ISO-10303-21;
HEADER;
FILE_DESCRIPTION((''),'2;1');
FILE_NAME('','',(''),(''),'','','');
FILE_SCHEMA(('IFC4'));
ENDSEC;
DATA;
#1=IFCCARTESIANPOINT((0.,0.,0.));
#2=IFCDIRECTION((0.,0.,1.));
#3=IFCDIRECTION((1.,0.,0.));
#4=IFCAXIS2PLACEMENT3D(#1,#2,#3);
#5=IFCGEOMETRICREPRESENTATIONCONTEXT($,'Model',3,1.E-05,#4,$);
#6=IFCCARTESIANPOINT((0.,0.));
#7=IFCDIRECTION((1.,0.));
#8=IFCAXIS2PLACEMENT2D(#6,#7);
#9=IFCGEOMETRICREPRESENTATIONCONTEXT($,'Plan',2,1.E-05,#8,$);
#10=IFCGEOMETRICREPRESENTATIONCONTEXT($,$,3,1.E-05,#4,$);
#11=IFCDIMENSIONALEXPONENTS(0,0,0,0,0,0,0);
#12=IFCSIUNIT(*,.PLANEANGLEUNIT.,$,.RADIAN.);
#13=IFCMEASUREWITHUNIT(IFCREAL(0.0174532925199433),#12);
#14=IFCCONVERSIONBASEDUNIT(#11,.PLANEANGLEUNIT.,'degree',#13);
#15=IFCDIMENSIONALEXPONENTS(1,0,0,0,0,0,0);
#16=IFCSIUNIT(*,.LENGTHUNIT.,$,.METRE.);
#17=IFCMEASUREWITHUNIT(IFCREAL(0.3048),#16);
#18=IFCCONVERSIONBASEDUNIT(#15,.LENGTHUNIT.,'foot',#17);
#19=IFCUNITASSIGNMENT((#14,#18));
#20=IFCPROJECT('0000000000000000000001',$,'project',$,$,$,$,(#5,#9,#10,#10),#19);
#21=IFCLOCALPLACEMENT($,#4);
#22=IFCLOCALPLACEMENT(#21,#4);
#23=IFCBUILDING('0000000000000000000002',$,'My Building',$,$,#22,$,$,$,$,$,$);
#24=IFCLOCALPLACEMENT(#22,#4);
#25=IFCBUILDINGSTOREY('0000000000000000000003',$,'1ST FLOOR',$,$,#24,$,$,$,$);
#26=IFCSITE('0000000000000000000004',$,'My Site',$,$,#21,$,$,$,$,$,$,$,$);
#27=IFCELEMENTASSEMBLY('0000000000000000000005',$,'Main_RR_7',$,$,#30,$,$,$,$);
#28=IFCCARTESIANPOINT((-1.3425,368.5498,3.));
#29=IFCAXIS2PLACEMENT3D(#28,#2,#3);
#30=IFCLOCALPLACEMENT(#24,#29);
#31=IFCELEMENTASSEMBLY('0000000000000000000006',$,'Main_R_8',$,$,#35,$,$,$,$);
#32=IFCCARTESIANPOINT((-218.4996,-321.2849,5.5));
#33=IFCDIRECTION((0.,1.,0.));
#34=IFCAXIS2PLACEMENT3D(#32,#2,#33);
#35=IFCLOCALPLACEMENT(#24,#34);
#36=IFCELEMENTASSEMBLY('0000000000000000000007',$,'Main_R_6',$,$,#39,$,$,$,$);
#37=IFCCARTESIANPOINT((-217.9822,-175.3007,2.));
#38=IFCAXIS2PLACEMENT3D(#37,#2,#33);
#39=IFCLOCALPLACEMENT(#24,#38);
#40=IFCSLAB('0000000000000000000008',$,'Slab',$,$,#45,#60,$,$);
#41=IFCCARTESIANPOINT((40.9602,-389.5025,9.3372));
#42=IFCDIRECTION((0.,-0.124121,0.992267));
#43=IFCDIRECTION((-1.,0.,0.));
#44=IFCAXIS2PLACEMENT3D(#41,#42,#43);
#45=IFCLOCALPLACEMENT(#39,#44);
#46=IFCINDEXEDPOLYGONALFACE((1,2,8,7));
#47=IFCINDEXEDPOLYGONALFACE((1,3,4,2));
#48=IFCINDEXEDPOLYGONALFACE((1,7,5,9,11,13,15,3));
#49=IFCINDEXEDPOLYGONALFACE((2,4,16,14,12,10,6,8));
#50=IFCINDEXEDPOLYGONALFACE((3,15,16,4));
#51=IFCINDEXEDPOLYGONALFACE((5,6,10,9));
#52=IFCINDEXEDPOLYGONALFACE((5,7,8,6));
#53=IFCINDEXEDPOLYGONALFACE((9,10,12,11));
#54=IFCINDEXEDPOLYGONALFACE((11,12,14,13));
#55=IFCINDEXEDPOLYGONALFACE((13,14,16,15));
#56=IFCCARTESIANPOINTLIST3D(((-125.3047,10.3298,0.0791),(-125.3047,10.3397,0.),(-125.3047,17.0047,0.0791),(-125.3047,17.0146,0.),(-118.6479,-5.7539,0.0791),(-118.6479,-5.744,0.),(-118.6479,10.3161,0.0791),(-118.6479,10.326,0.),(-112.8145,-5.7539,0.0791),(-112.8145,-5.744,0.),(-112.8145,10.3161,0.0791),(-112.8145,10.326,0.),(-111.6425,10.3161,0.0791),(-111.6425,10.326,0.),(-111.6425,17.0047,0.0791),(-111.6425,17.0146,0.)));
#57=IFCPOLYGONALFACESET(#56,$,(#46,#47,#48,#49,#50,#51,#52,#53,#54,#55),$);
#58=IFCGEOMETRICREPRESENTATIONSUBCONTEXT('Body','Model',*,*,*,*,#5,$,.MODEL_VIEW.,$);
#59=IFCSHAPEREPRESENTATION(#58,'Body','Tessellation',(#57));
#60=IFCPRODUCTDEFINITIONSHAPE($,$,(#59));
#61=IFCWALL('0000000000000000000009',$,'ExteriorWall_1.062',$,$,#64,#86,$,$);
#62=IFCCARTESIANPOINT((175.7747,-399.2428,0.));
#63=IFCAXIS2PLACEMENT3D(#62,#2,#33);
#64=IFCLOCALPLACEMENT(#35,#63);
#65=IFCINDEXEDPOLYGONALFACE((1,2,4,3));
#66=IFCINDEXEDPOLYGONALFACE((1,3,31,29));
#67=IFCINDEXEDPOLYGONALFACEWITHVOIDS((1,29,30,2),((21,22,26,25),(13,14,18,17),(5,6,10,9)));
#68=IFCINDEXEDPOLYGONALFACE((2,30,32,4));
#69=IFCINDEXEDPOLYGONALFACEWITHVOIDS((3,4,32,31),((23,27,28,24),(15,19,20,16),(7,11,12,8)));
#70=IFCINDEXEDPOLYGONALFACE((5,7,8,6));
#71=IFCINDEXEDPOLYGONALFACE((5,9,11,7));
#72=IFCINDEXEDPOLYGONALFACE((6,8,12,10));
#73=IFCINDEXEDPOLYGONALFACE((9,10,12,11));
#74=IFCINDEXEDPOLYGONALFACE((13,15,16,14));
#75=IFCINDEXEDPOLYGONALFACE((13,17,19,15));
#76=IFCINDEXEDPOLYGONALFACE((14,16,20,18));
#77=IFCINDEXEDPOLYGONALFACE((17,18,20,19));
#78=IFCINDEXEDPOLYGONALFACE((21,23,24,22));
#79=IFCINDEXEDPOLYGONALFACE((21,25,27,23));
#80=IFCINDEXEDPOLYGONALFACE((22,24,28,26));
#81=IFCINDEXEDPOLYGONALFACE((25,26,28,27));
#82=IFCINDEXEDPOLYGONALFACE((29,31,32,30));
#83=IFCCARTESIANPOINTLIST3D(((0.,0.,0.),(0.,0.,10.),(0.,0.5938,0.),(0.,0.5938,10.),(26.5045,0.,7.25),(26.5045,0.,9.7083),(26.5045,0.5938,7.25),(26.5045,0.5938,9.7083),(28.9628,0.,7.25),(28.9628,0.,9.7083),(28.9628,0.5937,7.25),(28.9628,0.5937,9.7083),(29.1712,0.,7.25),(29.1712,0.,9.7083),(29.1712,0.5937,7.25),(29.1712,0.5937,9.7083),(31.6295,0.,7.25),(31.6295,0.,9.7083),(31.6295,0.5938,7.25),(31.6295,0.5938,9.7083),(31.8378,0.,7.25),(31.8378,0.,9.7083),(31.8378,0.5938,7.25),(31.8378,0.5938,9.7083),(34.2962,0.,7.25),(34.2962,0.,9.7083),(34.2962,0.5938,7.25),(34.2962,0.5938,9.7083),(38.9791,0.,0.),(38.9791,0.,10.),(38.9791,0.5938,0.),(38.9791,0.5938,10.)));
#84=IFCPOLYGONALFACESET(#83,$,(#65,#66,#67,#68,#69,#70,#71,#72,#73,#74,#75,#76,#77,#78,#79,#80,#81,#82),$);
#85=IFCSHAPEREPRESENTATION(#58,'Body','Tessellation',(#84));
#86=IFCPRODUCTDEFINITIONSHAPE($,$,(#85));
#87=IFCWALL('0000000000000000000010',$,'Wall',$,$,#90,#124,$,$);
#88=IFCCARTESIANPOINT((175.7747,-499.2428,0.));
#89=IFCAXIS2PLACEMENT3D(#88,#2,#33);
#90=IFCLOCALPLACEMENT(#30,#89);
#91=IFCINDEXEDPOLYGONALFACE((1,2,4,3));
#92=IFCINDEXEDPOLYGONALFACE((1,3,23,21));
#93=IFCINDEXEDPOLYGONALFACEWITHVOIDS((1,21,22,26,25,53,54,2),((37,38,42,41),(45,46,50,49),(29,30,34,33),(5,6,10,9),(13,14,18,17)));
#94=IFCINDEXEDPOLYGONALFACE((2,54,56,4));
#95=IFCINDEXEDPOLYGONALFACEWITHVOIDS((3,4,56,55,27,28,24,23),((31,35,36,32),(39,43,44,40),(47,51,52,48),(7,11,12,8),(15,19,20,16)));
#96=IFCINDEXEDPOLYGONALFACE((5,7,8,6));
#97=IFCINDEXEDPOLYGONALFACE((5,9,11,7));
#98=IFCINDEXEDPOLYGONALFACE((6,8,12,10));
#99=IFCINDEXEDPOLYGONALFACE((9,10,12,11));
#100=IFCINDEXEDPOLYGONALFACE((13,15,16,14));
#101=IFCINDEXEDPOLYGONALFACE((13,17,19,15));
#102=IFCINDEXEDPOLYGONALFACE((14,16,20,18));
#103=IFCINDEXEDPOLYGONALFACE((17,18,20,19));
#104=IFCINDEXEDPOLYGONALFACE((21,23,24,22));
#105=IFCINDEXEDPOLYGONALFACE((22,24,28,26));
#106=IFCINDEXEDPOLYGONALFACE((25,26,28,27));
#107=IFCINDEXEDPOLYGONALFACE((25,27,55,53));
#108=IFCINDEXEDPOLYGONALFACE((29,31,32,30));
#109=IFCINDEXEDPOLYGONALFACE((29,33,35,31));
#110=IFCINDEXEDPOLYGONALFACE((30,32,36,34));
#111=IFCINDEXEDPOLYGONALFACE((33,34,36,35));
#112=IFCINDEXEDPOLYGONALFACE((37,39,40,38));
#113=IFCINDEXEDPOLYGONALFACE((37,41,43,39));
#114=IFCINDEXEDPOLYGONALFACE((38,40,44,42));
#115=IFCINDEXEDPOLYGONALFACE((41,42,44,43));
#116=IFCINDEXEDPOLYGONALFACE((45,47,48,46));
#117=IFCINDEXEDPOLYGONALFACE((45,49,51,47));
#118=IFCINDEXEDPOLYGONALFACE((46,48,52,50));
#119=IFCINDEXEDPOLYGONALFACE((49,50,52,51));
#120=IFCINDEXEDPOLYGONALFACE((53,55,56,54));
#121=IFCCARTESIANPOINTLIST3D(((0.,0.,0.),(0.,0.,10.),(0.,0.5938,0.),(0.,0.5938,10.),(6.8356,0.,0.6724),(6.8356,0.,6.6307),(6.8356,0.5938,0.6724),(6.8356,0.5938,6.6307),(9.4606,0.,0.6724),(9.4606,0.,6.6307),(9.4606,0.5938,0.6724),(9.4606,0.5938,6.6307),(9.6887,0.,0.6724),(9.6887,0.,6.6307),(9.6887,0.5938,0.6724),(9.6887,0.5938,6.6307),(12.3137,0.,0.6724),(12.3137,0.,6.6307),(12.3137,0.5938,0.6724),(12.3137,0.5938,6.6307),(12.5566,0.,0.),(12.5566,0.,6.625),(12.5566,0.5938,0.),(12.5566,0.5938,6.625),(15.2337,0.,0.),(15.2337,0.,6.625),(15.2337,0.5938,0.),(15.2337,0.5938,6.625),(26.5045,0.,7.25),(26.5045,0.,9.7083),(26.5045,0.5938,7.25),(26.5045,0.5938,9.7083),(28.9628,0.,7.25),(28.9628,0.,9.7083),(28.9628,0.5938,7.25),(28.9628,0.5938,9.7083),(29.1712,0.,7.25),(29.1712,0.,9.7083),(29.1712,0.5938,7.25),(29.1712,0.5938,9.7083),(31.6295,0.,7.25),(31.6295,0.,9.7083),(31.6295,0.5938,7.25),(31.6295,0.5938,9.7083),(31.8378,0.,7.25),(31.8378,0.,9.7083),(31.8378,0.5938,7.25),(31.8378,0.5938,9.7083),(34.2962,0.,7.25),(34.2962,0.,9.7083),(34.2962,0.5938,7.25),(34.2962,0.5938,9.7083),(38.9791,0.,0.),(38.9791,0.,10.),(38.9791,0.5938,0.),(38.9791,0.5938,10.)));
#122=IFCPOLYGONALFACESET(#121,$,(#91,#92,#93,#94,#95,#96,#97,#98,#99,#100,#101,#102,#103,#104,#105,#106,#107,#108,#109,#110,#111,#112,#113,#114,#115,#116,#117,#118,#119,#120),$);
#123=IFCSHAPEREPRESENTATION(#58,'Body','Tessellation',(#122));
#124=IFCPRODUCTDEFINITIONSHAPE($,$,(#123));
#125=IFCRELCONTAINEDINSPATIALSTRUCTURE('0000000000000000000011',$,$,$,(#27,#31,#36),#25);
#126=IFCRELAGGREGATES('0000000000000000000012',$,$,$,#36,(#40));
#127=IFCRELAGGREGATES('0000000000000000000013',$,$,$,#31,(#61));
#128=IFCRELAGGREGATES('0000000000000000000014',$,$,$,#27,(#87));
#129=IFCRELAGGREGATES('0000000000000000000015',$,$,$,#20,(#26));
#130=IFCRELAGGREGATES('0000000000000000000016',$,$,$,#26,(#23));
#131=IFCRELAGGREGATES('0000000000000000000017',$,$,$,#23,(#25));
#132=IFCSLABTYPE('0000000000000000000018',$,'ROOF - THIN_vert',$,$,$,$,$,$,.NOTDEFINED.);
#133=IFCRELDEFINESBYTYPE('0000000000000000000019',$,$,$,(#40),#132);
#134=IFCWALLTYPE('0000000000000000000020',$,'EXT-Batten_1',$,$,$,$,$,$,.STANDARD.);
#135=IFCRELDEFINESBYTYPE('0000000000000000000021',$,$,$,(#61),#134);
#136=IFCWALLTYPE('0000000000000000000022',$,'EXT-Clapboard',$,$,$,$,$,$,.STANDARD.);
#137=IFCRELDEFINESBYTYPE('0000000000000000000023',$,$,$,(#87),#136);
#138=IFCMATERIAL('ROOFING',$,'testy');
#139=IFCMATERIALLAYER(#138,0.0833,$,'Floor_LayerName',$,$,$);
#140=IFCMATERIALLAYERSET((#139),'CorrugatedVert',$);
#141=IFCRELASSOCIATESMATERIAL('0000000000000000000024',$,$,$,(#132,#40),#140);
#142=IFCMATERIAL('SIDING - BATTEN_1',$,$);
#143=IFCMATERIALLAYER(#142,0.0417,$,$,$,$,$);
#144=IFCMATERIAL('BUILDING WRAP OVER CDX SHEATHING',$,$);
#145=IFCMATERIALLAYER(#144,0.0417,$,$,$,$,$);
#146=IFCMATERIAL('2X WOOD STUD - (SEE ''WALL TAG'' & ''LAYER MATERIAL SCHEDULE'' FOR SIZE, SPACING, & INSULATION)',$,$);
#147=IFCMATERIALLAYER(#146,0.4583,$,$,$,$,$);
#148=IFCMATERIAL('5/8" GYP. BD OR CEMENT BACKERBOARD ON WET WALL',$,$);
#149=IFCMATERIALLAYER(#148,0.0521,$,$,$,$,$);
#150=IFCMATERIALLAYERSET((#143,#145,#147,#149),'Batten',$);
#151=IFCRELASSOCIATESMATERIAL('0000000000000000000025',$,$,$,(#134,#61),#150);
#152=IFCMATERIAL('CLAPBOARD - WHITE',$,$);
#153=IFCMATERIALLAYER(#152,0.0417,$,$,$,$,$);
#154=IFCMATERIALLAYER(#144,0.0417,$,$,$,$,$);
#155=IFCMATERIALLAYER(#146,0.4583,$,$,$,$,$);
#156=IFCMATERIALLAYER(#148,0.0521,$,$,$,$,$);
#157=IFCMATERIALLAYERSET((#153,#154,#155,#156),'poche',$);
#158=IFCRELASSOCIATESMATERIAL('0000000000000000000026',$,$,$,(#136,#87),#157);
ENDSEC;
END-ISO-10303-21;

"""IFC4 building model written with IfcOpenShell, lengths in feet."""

from ifc_helpers import new_model, entity, si_unit, converted_unit, frame, origin_with_axes, origin_2d_with_axis, place, context, subcontext, project, spatial, line, indexed_curve, outline, extrude, source, transform, mapped, material, layer, layer_set, layer_usage, type_object, element, aggregate, save


model = new_model("IFC4")

# Units and contexts
model_context = context("Model", 3, precision=1e-05, world=origin_with_axes())
plan_context = context("Plan", 2, precision=1e-05, world=origin_2d_with_axis())
context_of_model = context(None, 3, precision=1e-05, world=origin_with_axes())
body_context = subcontext(model_context, "Body", "Model", "MODEL_VIEW")
ifc_project = project(units=[converted_unit("PLANEANGLEUNIT", "degree", entity("IfcReal", 0.0174532925199433), si_unit("PLANEANGLEUNIT", "RADIAN"), dimensions=[0, 0, 0, 0, 0, 0, 0]), converted_unit("LENGTHUNIT", "foot", entity("IfcReal", 0.3048), si_unit("LENGTHUNIT", "METRE"), dimensions=[1, 0, 0, 0, 0, 0, 0])], contexts=[model_context, plan_context, context_of_model, context_of_model])

# Site, building, storey
site_placement = place(None, origin_with_axes())
site = spatial("IfcSite", under=ifc_project, at=site_placement, Name="My Site")
building_placement = place(site_placement, origin_with_axes())
building = spatial("IfcBuilding", under=site, at=building_placement, Name="My Building")
storey_placement = place(building_placement, origin_with_axes())
storey = spatial("IfcBuildingStorey", under=building, at=storey_placement, Name="1ST FLOOR")

# Element assembly
assembly_1_placement = place(storey_placement, frame((-1.3425, 368.5498, 3.0), z_axis=(0.0, 0.0, 1.0), x_axis=(1.0, 0.0, 0.0)))
assembly_1 = element("IfcElementAssembly", 1, at=assembly_1_placement, inside=storey, Name="Main_RR_7")

# Element assembly
assembly_2_placement = place(storey_placement, frame((-218.4996, -321.2849, 5.5), z_axis=(0.0, 0.0, 1.0), x_axis=(0.0, 1.0, 0.0)))
assembly_2 = element("IfcElementAssembly", 2, at=assembly_2_placement, inside=storey, Name="Main_R_8")

# Element assembly, slab
assembly_3_placement = place(storey_placement, frame((-217.9822, -175.3007, 2.0), z_axis=(0.0, 0.0, 1.0), x_axis=(0.0, 1.0, 0.0)))
assembly_3 = element("IfcElementAssembly", 3, at=assembly_3_placement, inside=storey, Name="Main_R_6")
ifc_material_1 = material(Name="ROOFING", Category="testy")
ifc_layer_1 = layer(ifc_material_1, 0.0833, Name="Floor_LayerName")
ifc_layer_set_1 = layer_set([ifc_layer_1], Name="CorrugatedVert")
ifc_layer_usage_1 = layer_usage(ifc_layer_set_1, "AXIS3", "POSITIVE", 0.0)
slab_type_1 = type_object("IfcSlabType", Name="ROOF - THIN_vert", PredefinedType="NOTDEFINED", material=ifc_layer_set_1)
slab_1_placement = place(assembly_3_placement, frame((40.9602, -389.5025, 9.3372), z_axis=(0.0, -0.124121, 0.992267), x_axis=(-1.0, 0.0, 0.0)))
slab_1 = element("IfcSlab", 4, at=slab_1_placement, type_object=slab_type_1, material=ifc_layer_usage_1, Name="Slab", context=body_context, shape_type="SweptSolid", body=[
    extrude(outline(indexed_curve([(-118.6479, -5.744), (-118.6479, 10.326), (-125.3047, 10.3397), (-125.3047, 17.0146), (-111.6425, 17.0146), (-111.6425, 10.326), (-112.8145, 10.326), (-112.8145, -5.744)], segments=[line(1, 8), line(8, 7), line(7, 6), line(6, 5), line(5, 4), line(4, 3), line(3, 2), line(2, 1)], self_intersect=False)), None, (0.0, -0.124121, 0.992267), 0.0797),
])
aggregate(assembly_3, [slab_1])

# Wall, openings
ifc_material_2 = material(Name="SIDING - BATTEN_1")
ifc_layer_2 = layer(ifc_material_2, 0.0417)
ifc_material_3 = material(Name="BUILDING WRAP OVER CDX SHEATHING")
ifc_layer_3 = layer(ifc_material_3, 0.0417)
ifc_material_4 = material(Name="2X WOOD STUD - (SEE 'WALL TAG' & 'LAYER MATERIAL SCHEDULE' FOR SIZE, SPACING, & INSULATION)")
ifc_layer_4 = layer(ifc_material_4, 0.4583)
ifc_material_5 = material(Name="5/8\" GYP. BD OR CEMENT BACKERBOARD ON WET WALL")
ifc_layer_5 = layer(ifc_material_5, 0.0521)
ifc_layer_set_2 = layer_set([ifc_layer_2, ifc_layer_3, ifc_layer_4, ifc_layer_5], Name="Batten")
ifc_layer_usage_2 = layer_usage(ifc_layer_set_2, "AXIS2", "POSITIVE", 0.0)
wall_type_1 = type_object("IfcWallType", Name="EXT-Batten_1", PredefinedType="STANDARD", material=ifc_layer_set_2)
wall_1_placement = place(assembly_2_placement, frame((175.7747, -399.2428, 0.0), z_axis=(0.0, 0.0, 1.0), x_axis=(0.0, 1.0, 0.0)))
wall_1 = element("IfcWall", 5, at=wall_1_placement, type_object=wall_type_1, material=ifc_layer_usage_2, Name="ExteriorWall_1.062", context=body_context, shape_type="SweptSolid", body=[
    extrude(outline(indexed_curve([(0.0, 0.0), (0.0, 0.5938), (38.9791, 0.5938), (38.9791, 0.0), (0.0, 0.0)], self_intersect=False)), origin_with_axes(), (0.0, 0.0, 1.0), 10.0),
])
shared_shape_1 = source(origin_with_axes(), body_context, "Body", "SweptSolid", [
    extrude(outline(indexed_curve([(0.0, 0.0), (2.4583, 0.0), (2.4583, 2.4583), (0.0, 2.4583)], segments=[line(1, 2, 3, 4, 1)])), frame((0.0, -1.9685, 0.0), z_axis=(0.0, -1.0, 0.0), x_axis=(1.0, 0.0, 0.0)), (0.0, 0.0, -1.0), 3.937),
])
opening_1_placement = place(wall_1_placement, frame((31.8378, 0.0, 7.25), z_axis=(0.0, 0.0, 1.0), x_axis=(1.0, 0.0, 0.0)))
element("IfcOpeningElement", 6, at=opening_1_placement, cuts=wall_1, PredefinedType="OPENING", context=body_context, shape_type="MappedRepresentation", body=[
    mapped(shared_shape_1, transform((0.0, 0.0, 0.0), x_axis=(1.0, 0.0, 0.0), y_axis=(0.0, 1.0, 0.0), z_axis=(0.0, 0.0, 1.0), scale=1.0)),
])
opening_2_placement = place(wall_1_placement, frame((26.5045, 0.0, 7.25), z_axis=(0.0, 0.0, 1.0), x_axis=(1.0, 0.0, 0.0)))
element("IfcOpeningElement", 7, at=opening_2_placement, cuts=wall_1, PredefinedType="OPENING", context=body_context, shape_type="MappedRepresentation", body=[
    mapped(shared_shape_1, transform((0.0, 0.0, 0.0), x_axis=(1.0, 0.0, 0.0), y_axis=(0.0, 1.0, 0.0), z_axis=(0.0, 0.0, 1.0), scale=1.0)),
])
opening_3_placement = place(wall_1_placement, frame((29.1712, 0.0, 7.25), z_axis=(0.0, 0.0, 1.0), x_axis=(1.0, 0.0, 0.0)))
element("IfcOpeningElement", 8, at=opening_3_placement, cuts=wall_1, PredefinedType="OPENING", context=body_context, shape_type="MappedRepresentation", body=[
    mapped(shared_shape_1, transform((0.0, 0.0, 0.0), x_axis=(1.0, 0.0, 0.0), y_axis=(0.0, 1.0, 0.0), z_axis=(0.0, 0.0, 1.0), scale=1.0)),
])

aggregate(assembly_2, [wall_1])

# Wall, openings
ifc_material_6 = material(Name="CLAPBOARD - WHITE")
ifc_layer_6 = layer(ifc_material_6, 0.0417)
ifc_layer_7 = layer(ifc_material_3, 0.0417)
ifc_layer_8 = layer(ifc_material_4, 0.4583)
ifc_layer_9 = layer(ifc_material_5, 0.0521)
ifc_layer_set_3 = layer_set([ifc_layer_6, ifc_layer_7, ifc_layer_8, ifc_layer_9], Name="poche")
ifc_layer_usage_3 = layer_usage(ifc_layer_set_3, "AXIS2", "POSITIVE", 0.0)
wall_type_2 = type_object("IfcWallType", Name="EXT-Clapboard", PredefinedType="STANDARD", material=ifc_layer_set_3)
wall_2_placement = place(assembly_1_placement, frame((175.7747, -499.2428, 0.0), z_axis=(0.0, 0.0, 1.0), x_axis=(0.0, 1.0, 0.0)))
wall_2 = element("IfcWall", 9, at=wall_2_placement, type_object=wall_type_2, material=ifc_layer_usage_3, Name="Wall", context=body_context, shape_type="SweptSolid", body=[
    extrude(outline(indexed_curve([(0.0, 0.0), (0.0, 0.5938), (38.9791, 0.5938), (38.9791, 0.0), (0.0, 0.0)], self_intersect=False)), origin_with_axes(), (0.0, 0.0, 1.0), 10.0),
])
opening_4_placement = place(wall_2_placement, frame((26.5045, 0.0, 7.25), z_axis=(0.0, 0.0, 1.0), x_axis=(1.0, 0.0, 0.0)))
element("IfcOpeningElement", 10, at=opening_4_placement, cuts=wall_2, PredefinedType="OPENING", context=body_context, shape_type="MappedRepresentation", body=[
    mapped(shared_shape_1, transform((0.0, 0.0, 0.0), x_axis=(1.0, 0.0, 0.0), y_axis=(0.0, 1.0, 0.0), z_axis=(0.0, 0.0, 1.0), scale=1.0)),
])
opening_5_placement = place(wall_2_placement, frame((29.1712, 0.0, 7.25), z_axis=(0.0, 0.0, 1.0), x_axis=(1.0, 0.0, 0.0)))
element("IfcOpeningElement", 11, at=opening_5_placement, cuts=wall_2, PredefinedType="OPENING", context=body_context, shape_type="MappedRepresentation", body=[
    mapped(shared_shape_1, transform((0.0, 0.0, 0.0), x_axis=(1.0, 0.0, 0.0), y_axis=(0.0, 1.0, 0.0), z_axis=(0.0, 0.0, 1.0), scale=1.0)),
])
opening_6_placement = place(wall_2_placement, frame((31.8378, 0.0, 7.25), z_axis=(0.0, 0.0, 1.0), x_axis=(1.0, 0.0, 0.0)))
element("IfcOpeningElement", 12, at=opening_6_placement, cuts=wall_2, PredefinedType="OPENING", context=body_context, shape_type="MappedRepresentation", body=[
    mapped(shared_shape_1, transform((0.0, 0.0, 0.0), x_axis=(1.0, 0.0, 0.0), y_axis=(0.0, 1.0, 0.0), z_axis=(0.0, 0.0, 1.0), scale=1.0)),
])
shared_shape_2 = source(origin_with_axes(), body_context, "Body", "SweptSolid", [
    extrude(outline(indexed_curve([(0.0, 0.0), (2.6771, 0.0), (2.6771, 6.625), (0.0, 6.625)], segments=[line(1, 2, 3, 4, 1)])), frame((0.0, -1.9685, 0.0), z_axis=(0.0, -1.0, 0.0), x_axis=(1.0, 0.0, 0.0)), (0.0, 0.0, -1.0), 3.937),
])
opening_7_placement = place(wall_2_placement, frame((12.5566, 0.0, 0.0), z_axis=(0.0, 0.0, 1.0), x_axis=(1.0, 0.0, 0.0)))
element("IfcOpeningElement", 13, at=opening_7_placement, cuts=wall_2, PredefinedType="OPENING", context=body_context, shape_type="MappedRepresentation", body=[
    mapped(shared_shape_2, transform((0.0, 0.0, 0.0), x_axis=(1.0, 0.0, 0.0), y_axis=(0.0, 1.0, 0.0), z_axis=(0.0, 0.0, 1.0), scale=1.0)),
])
shared_shape_3 = source(origin_with_axes(), body_context, "Body", "SweptSolid", [
    extrude(outline(indexed_curve([(0.0, 0.0), (2.625, 0.0), (2.625, 5.9583), (0.0, 5.9583)], segments=[line(1, 2, 3, 4, 1)])), frame((0.0, -1.9685, 0.0), z_axis=(0.0, -1.0, 0.0), x_axis=(1.0, 0.0, 0.0)), (0.0, 0.0, -1.0), 3.937),
])
opening_8_placement = place(wall_2_placement, frame((9.6887, 0.0, 0.6724), z_axis=(0.0, 0.0, 1.0), x_axis=(1.0, 0.0, 0.0)))
element("IfcOpeningElement", 14, at=opening_8_placement, cuts=wall_2, PredefinedType="OPENING", context=body_context, shape_type="MappedRepresentation", body=[
    mapped(shared_shape_3, transform((0.0, 0.0, 0.0), x_axis=(1.0, 0.0, 0.0), y_axis=(0.0, 1.0, 0.0), z_axis=(0.0, 0.0, 1.0), scale=1.0)),
])
opening_9_placement = place(wall_2_placement, frame((6.8356, 0.0, 0.6724), z_axis=(0.0, 0.0, 1.0), x_axis=(1.0, 0.0, 0.0)))
element("IfcOpeningElement", 15, at=opening_9_placement, cuts=wall_2, PredefinedType="OPENING", context=body_context, shape_type="MappedRepresentation", body=[
    mapped(shared_shape_3, transform((0.0, 0.0, 0.0), x_axis=(1.0, 0.0, 0.0), y_axis=(0.0, 1.0, 0.0), z_axis=(0.0, 0.0, 1.0), scale=1.0)),
])

aggregate(assembly_1, [wall_2])

save(model, "model.ifc")
